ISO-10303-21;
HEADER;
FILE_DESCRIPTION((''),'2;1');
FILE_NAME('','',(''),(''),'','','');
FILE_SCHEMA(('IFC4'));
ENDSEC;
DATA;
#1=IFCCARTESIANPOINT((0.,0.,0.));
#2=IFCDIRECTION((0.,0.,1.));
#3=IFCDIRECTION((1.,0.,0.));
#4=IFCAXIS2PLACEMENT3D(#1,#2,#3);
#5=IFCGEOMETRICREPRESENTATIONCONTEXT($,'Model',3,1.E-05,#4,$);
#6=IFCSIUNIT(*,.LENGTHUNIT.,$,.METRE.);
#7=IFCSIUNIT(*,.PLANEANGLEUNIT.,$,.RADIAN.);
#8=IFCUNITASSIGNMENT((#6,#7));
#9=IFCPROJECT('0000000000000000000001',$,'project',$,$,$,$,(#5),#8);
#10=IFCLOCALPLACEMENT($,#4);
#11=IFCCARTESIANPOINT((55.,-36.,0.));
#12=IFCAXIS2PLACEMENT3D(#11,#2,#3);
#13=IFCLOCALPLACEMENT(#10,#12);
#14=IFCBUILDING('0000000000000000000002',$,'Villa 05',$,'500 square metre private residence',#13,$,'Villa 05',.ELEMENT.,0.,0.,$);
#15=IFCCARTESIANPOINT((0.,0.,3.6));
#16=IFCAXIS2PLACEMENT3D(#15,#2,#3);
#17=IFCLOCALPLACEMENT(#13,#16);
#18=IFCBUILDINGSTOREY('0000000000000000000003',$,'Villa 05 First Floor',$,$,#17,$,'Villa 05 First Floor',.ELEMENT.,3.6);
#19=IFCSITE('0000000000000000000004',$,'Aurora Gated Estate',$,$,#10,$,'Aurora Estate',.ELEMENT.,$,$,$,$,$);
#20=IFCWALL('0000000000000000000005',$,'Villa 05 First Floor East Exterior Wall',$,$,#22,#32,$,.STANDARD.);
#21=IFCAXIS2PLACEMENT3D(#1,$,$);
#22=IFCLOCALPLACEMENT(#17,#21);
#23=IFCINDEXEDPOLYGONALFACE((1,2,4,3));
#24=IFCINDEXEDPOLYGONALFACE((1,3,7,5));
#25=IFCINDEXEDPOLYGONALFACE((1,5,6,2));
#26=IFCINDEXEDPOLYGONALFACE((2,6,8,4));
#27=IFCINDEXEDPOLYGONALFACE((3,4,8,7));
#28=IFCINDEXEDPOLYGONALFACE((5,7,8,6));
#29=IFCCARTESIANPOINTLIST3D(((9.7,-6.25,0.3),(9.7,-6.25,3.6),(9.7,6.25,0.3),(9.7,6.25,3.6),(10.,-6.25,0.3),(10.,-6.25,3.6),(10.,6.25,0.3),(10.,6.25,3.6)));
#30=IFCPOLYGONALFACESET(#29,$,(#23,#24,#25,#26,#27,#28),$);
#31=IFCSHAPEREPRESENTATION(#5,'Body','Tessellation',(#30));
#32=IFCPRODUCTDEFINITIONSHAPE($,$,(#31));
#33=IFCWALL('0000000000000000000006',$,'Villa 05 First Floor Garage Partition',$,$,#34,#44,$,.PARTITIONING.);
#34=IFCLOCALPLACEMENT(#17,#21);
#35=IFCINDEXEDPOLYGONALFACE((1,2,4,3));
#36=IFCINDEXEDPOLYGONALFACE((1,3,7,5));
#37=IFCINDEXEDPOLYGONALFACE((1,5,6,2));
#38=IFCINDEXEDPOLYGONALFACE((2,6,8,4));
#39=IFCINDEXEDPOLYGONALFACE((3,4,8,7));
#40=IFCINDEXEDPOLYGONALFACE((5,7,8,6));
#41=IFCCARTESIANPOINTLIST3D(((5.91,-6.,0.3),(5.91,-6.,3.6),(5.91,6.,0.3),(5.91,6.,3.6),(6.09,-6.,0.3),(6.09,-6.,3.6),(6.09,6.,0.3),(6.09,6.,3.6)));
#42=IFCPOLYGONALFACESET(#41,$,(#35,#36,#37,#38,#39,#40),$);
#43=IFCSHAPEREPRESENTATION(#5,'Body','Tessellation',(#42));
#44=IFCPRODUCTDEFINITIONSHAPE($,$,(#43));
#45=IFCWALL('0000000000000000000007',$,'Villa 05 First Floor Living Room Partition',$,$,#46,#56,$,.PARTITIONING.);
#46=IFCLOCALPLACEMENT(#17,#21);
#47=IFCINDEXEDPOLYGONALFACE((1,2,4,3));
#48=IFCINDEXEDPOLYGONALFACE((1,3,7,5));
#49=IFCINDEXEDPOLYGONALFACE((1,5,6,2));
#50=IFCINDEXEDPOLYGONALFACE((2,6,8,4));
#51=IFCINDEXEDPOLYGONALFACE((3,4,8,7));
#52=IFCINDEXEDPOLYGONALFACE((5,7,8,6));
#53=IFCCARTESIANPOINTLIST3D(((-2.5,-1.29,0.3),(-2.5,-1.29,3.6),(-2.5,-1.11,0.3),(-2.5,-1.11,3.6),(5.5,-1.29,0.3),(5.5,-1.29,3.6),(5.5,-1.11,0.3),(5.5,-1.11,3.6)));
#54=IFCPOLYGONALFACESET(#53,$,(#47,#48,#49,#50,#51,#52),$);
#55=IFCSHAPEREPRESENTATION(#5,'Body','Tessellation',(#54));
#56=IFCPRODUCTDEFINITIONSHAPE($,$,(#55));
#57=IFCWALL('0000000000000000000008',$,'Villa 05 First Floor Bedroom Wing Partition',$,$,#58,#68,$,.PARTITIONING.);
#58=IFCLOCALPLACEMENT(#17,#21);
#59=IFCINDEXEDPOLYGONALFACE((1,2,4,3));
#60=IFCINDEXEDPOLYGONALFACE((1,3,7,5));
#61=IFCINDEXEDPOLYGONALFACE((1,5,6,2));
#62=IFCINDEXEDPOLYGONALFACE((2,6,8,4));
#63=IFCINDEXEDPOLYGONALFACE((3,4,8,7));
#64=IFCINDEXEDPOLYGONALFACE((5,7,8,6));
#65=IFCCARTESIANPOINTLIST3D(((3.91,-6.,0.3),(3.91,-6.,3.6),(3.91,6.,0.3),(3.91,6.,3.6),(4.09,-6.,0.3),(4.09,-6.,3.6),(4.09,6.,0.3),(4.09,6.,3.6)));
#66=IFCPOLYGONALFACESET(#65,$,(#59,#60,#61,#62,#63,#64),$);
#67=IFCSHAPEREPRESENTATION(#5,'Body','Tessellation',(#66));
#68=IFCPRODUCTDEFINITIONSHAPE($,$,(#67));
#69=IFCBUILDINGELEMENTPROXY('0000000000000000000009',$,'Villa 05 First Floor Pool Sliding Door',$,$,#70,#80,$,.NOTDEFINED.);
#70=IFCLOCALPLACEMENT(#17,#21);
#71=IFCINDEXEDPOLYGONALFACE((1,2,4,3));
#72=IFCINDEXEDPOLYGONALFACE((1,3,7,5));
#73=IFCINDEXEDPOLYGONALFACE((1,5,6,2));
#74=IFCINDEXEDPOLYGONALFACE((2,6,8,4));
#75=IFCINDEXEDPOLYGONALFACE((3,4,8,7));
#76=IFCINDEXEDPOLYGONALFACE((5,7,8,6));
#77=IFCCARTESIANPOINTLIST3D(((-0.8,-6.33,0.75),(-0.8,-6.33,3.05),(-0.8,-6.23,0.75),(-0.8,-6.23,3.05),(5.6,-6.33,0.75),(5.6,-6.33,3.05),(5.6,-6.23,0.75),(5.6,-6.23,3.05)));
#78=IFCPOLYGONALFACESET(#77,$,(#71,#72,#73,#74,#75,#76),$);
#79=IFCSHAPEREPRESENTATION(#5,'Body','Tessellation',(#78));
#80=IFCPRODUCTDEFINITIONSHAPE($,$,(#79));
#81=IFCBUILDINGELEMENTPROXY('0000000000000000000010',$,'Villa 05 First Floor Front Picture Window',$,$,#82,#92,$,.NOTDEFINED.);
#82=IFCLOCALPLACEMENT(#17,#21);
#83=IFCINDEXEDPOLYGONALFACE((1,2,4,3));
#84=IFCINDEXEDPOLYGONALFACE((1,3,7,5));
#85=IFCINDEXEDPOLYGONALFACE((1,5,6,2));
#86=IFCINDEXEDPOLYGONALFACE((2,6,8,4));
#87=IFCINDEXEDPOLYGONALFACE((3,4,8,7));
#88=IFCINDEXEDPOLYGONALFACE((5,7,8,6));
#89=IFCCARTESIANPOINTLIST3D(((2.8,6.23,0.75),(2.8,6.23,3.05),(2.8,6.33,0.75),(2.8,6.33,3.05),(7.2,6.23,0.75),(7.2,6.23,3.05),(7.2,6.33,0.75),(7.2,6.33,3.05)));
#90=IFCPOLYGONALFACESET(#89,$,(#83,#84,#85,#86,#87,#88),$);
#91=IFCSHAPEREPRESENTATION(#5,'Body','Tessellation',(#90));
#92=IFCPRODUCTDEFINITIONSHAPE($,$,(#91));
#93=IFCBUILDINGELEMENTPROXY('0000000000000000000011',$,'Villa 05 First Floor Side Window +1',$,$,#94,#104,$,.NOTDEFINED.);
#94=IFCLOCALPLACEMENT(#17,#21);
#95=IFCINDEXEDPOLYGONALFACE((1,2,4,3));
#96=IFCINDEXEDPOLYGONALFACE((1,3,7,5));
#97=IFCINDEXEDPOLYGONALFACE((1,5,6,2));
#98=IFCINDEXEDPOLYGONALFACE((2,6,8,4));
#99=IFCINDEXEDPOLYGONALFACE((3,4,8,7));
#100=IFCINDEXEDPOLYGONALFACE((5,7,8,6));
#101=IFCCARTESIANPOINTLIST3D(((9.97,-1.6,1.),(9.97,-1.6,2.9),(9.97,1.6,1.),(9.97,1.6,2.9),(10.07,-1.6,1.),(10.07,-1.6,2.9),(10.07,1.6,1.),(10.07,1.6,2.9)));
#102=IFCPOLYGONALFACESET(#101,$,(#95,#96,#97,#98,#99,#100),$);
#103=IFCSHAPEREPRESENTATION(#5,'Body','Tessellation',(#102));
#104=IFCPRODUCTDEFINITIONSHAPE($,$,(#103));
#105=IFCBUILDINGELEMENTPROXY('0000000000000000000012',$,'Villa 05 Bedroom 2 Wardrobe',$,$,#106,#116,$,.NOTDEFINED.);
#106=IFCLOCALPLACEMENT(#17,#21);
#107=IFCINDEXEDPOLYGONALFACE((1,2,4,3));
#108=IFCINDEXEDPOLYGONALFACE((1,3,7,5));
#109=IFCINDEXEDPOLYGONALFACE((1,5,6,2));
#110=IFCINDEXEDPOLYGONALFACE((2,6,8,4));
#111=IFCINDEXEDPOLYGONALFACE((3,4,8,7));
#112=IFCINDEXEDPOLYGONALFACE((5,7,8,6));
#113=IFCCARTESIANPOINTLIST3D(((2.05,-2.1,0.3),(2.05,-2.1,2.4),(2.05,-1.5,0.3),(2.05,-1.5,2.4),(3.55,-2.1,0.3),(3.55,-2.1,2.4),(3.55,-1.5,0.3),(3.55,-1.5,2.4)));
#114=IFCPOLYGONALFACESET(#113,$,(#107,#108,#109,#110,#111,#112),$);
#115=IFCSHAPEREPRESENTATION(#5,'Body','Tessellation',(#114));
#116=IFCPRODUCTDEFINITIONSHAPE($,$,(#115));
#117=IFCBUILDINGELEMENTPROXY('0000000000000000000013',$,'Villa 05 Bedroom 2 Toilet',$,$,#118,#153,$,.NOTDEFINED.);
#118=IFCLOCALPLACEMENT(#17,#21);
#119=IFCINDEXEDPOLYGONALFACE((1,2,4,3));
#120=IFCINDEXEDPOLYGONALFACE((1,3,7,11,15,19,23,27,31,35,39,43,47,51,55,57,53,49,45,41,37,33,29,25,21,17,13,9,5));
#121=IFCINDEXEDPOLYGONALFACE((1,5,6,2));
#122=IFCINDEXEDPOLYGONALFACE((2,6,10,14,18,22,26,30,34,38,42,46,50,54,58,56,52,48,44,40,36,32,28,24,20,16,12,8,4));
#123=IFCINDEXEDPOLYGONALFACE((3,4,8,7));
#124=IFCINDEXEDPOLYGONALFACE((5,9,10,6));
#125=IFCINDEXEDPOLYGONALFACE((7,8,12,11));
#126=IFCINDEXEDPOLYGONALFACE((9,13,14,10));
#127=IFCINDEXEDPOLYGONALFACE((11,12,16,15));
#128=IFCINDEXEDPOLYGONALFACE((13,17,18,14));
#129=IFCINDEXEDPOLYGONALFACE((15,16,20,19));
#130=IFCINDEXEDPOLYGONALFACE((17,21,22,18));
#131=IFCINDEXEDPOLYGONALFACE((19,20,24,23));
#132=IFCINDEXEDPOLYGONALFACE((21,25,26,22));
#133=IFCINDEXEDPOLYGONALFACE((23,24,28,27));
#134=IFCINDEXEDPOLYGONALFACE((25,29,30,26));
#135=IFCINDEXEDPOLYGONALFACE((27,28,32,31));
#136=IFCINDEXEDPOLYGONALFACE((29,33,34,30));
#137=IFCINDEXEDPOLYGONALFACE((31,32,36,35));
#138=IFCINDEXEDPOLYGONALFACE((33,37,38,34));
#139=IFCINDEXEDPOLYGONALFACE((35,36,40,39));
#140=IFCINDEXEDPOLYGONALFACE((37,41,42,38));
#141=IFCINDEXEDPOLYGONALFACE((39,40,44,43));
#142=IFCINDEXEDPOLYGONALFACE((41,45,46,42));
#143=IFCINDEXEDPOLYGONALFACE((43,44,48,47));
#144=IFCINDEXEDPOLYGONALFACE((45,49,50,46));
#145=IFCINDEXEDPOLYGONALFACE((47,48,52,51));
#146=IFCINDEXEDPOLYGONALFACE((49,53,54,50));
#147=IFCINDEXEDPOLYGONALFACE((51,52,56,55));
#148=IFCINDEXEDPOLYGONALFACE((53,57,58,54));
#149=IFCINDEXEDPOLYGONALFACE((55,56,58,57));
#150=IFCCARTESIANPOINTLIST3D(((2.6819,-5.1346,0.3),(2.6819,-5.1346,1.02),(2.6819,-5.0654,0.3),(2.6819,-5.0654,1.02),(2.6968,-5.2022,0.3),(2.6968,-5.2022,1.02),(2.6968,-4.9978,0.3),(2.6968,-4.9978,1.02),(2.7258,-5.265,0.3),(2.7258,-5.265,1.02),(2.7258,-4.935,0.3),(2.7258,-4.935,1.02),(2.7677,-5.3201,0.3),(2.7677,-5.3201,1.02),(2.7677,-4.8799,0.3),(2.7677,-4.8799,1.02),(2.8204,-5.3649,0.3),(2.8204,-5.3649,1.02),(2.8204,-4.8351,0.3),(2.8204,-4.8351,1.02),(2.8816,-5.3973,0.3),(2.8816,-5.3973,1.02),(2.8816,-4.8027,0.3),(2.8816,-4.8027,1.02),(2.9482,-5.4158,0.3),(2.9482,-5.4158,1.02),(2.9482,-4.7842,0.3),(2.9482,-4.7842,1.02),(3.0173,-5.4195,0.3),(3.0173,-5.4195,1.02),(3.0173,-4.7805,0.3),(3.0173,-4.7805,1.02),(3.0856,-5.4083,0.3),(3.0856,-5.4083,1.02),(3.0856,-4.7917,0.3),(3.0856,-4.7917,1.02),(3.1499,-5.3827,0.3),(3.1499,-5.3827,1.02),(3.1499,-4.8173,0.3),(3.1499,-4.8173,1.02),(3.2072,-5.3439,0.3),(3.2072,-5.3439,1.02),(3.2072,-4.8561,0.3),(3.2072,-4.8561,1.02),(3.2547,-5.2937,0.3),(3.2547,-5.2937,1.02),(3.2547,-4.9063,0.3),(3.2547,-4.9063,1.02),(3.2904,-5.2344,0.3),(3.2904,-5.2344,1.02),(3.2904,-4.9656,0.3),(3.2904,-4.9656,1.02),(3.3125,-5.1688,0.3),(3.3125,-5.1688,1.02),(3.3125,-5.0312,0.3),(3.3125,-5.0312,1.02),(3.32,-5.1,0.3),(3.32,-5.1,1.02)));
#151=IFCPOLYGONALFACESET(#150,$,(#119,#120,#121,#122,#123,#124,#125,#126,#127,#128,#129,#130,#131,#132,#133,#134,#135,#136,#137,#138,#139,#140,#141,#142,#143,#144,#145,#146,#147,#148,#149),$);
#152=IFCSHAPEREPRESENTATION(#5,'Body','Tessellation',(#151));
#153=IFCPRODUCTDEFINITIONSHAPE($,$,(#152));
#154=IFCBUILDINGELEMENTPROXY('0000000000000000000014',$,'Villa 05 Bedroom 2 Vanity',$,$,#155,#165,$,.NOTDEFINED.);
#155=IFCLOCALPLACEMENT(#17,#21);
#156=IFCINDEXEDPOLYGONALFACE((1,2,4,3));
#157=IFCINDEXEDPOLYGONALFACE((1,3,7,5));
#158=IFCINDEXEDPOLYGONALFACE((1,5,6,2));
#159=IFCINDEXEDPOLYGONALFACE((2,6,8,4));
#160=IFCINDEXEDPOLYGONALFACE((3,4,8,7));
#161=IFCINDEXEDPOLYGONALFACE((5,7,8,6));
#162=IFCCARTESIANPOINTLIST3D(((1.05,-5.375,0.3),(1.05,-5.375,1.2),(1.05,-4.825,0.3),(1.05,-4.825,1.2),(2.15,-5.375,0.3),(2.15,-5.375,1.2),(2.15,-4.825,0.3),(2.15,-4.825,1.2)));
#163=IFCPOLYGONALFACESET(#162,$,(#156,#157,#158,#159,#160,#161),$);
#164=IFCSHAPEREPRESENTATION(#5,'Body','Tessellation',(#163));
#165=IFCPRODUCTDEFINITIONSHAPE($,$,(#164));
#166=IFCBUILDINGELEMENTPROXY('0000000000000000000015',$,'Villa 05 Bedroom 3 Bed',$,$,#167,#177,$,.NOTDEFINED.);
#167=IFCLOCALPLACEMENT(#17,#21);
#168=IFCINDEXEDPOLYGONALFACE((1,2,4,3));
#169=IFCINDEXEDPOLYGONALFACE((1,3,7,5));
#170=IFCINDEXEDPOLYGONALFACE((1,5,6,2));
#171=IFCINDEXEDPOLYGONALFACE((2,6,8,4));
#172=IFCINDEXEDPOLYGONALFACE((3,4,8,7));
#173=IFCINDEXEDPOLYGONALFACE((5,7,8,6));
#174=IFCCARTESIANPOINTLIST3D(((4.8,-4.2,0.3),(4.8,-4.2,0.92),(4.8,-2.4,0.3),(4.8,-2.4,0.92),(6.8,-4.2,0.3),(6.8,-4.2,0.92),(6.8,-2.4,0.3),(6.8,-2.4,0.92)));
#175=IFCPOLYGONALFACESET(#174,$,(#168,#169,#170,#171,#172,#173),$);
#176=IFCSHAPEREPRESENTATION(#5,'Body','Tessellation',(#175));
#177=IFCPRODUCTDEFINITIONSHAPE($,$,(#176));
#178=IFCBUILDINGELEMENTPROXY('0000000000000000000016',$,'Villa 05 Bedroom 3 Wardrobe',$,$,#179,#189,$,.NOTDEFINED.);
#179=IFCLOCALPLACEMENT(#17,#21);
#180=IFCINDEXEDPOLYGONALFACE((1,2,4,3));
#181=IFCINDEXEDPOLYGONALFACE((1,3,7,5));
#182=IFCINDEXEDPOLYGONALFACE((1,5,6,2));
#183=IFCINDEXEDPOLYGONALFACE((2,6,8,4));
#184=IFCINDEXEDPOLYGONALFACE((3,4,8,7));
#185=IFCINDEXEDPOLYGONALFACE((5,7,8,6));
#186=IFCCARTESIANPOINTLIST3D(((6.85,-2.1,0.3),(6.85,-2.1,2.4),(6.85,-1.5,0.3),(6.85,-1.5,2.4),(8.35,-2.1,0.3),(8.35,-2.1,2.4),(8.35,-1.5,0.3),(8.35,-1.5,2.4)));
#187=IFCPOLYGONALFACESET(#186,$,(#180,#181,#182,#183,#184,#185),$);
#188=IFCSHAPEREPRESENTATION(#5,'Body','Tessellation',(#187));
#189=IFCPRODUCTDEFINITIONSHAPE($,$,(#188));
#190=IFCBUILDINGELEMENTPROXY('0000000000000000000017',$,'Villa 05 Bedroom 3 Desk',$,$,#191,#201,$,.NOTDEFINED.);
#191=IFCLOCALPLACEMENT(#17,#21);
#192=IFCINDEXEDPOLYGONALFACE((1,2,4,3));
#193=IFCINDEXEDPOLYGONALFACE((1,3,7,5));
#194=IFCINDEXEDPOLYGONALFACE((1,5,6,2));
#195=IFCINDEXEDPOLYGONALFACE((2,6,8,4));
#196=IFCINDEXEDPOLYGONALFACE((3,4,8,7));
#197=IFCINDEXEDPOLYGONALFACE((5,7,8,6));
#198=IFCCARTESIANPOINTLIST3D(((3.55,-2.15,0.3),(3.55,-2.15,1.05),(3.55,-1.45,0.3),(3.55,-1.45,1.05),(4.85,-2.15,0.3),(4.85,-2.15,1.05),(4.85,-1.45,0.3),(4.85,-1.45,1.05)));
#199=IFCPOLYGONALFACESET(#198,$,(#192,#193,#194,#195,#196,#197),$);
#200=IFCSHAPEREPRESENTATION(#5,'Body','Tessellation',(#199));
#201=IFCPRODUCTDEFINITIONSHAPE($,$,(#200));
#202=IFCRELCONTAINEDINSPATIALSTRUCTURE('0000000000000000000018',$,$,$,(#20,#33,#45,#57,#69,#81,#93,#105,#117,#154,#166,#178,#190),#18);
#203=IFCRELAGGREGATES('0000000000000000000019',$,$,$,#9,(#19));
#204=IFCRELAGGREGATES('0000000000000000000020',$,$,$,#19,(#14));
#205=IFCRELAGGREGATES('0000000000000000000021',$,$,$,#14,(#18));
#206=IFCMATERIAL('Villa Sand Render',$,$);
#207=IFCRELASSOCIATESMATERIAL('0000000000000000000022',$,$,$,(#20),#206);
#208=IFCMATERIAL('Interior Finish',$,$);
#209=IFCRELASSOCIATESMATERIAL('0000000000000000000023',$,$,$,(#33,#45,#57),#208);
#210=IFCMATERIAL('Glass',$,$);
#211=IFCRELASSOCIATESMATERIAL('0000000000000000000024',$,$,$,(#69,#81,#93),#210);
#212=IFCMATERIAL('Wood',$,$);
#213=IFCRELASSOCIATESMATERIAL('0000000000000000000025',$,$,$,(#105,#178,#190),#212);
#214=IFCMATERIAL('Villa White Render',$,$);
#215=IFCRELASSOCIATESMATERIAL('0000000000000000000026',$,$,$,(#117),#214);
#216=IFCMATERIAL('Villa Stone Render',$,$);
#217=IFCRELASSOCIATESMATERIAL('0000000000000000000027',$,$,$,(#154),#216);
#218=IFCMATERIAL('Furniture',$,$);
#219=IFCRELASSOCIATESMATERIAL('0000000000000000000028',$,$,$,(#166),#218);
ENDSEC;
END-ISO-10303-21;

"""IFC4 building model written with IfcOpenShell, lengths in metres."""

from ifc_helpers import new_model, si_unit, frame, origin_with_axes, origin_2d_with_axis, place, context, project, spatial, rectangle, circle, extrude, material, element, save


model = new_model("IFC4")

# Units and contexts
model_context = context("Model", 3, precision=1e-05, world=origin_with_axes())
ifc_project = project(units=[si_unit("LENGTHUNIT", "METRE"), si_unit("PLANEANGLEUNIT", "RADIAN")], contexts=[model_context])

# Site, building, storey
site_placement = place(None, origin_with_axes())
site = spatial("IfcSite", under=ifc_project, at=site_placement, Name="Aurora Gated Estate", LongName="Aurora Estate", CompositionType="ELEMENT")
building_placement = place(site_placement, frame((55.0, -36.0, 0.0), z_axis=(0.0, 0.0, 1.0), x_axis=(1.0, 0.0, 0.0)))
building = spatial("IfcBuilding", under=site, at=building_placement, Name="Villa 05", ObjectType="500 square metre private residence", LongName="Villa 05", CompositionType="ELEMENT", ElevationOfRefHeight=0.0, ElevationOfTerrain=0.0)
storey_placement = place(building_placement, frame((0.0, 0.0, 3.6), z_axis=(0.0, 0.0, 1.0), x_axis=(1.0, 0.0, 0.0)))
storey = spatial("IfcBuildingStorey", under=building, at=storey_placement, Name="Villa 05 First Floor", LongName="Villa 05 First Floor", CompositionType="ELEMENT", Elevation=3.6)

# Walls
ifc_material_1 = material(Name="Villa Sand Render")
wall_1_placement = place(storey_placement, frame((9.85, 0.0, 0.3), z_axis=(0.0, 0.0, 1.0), x_axis=(1.0, 0.0, 0.0)))
element("IfcWall", 1, at=wall_1_placement, inside=storey, material=ifc_material_1, Name="Villa 05 First Floor East Exterior Wall", PredefinedType="STANDARD", context=model_context, shape_type="SweptSolid", body=[
    extrude(rectangle(XDim=0.3, YDim=12.5, at=origin_2d_with_axis()), origin_with_axes(), (0.0, 0.0, 1.0), 3.3),
])
ifc_material_2 = material(Name="Interior Finish")
wall_2_placement = place(storey_placement, frame((6.0, 0.0, 0.3), z_axis=(0.0, 0.0, 1.0), x_axis=(1.0, 0.0, 0.0)))
element("IfcWall", 2, at=wall_2_placement, inside=storey, material=ifc_material_2, Name="Villa 05 First Floor Garage Partition", PredefinedType="PARTITIONING", context=model_context, shape_type="SweptSolid", body=[
    extrude(rectangle(XDim=0.18, YDim=12.0, at=origin_2d_with_axis()), origin_with_axes(), (0.0, 0.0, 1.0), 3.3),
])
wall_3_placement = place(storey_placement, frame((1.5, -1.2, 0.3), z_axis=(0.0, 0.0, 1.0), x_axis=(1.0, 0.0, 0.0)))
element("IfcWall", 3, at=wall_3_placement, inside=storey, material=ifc_material_2, Name="Villa 05 First Floor Living Room Partition", PredefinedType="PARTITIONING", context=model_context, shape_type="SweptSolid", body=[
    extrude(rectangle(XDim=8.0, YDim=0.18, at=origin_2d_with_axis()), origin_with_axes(), (0.0, 0.0, 1.0), 3.3),
])
wall_4_placement = place(storey_placement, frame((4.0, 0.0, 0.3), z_axis=(0.0, 0.0, 1.0), x_axis=(1.0, 0.0, 0.0)))
element("IfcWall", 4, at=wall_4_placement, inside=storey, material=ifc_material_2, Name="Villa 05 First Floor Bedroom Wing Partition", PredefinedType="PARTITIONING", context=model_context, shape_type="SweptSolid", body=[
    extrude(rectangle(XDim=0.18, YDim=12.0, at=origin_2d_with_axis()), origin_with_axes(), (0.0, 0.0, 1.0), 3.3),
])

# Building element proxies
ifc_material_3 = material(Name="Glass")
proxy_1_placement = place(storey_placement, frame((2.4, -6.28, 0.75), z_axis=(0.0, 0.0, 1.0), x_axis=(1.0, 0.0, 0.0)))
element("IfcBuildingElementProxy", 5, at=proxy_1_placement, inside=storey, material=ifc_material_3, Name="Villa 05 First Floor Pool Sliding Door", PredefinedType="NOTDEFINED", context=model_context, shape_type="SweptSolid", body=[
    extrude(rectangle(XDim=6.4, YDim=0.1, at=origin_2d_with_axis()), origin_with_axes(), (0.0, 0.0, 1.0), 2.3),
])
proxy_2_placement = place(storey_placement, frame((5.0, 6.28, 0.75), z_axis=(0.0, 0.0, 1.0), x_axis=(1.0, 0.0, 0.0)))
element("IfcBuildingElementProxy", 6, at=proxy_2_placement, inside=storey, material=ifc_material_3, Name="Villa 05 First Floor Front Picture Window", PredefinedType="NOTDEFINED", context=model_context, shape_type="SweptSolid", body=[
    extrude(rectangle(XDim=4.4, YDim=0.1, at=origin_2d_with_axis()), origin_with_axes(), (0.0, 0.0, 1.0), 2.3),
])
proxy_3_placement = place(storey_placement, frame((10.02, 0.0, 1.0), z_axis=(0.0, 0.0, 1.0), x_axis=(0.0, 1.0, 0.0)))
element("IfcBuildingElementProxy", 7, at=proxy_3_placement, inside=storey, material=ifc_material_3, Name="Villa 05 First Floor Side Window +1", PredefinedType="NOTDEFINED", context=model_context, shape_type="SweptSolid", body=[
    extrude(rectangle(XDim=3.2, YDim=0.1, at=origin_2d_with_axis()), origin_with_axes(), (0.0, 0.0, 1.0), 1.9),
])
ifc_material_4 = material(Name="Wood")
proxy_4_placement = place(storey_placement, frame((2.8, -1.8, 0.3), z_axis=(0.0, 0.0, 1.0), x_axis=(1.0, 0.0, 0.0)))
element("IfcBuildingElementProxy", 8, at=proxy_4_placement, inside=storey, material=ifc_material_4, Name="Villa 05 Bedroom 2 Wardrobe", PredefinedType="NOTDEFINED", context=model_context, shape_type="SweptSolid", body=[
    extrude(rectangle(XDim=1.5, YDim=0.6, at=origin_2d_with_axis()), origin_with_axes(), (0.0, 0.0, 1.0), 2.1),
])
ifc_material_5 = material(Name="Villa White Render")
proxy_5_placement = place(storey_placement, frame((3.0, -5.1, 0.3), z_axis=(0.0, 0.0, 1.0), x_axis=(1.0, 0.0, 0.0)))
element("IfcBuildingElementProxy", 9, at=proxy_5_placement, inside=storey, material=ifc_material_5, Name="Villa 05 Bedroom 2 Toilet", PredefinedType="NOTDEFINED", context=model_context, shape_type="SweptSolid", body=[
    extrude(circle(Radius=0.32, at=origin_2d_with_axis()), origin_with_axes(), (0.0, 0.0, 1.0), 0.72),
])
ifc_material_6 = material(Name="Villa Stone Render")
proxy_6_placement = place(storey_placement, frame((1.6, -5.1, 0.3), z_axis=(0.0, 0.0, 1.0), x_axis=(1.0, 0.0, 0.0)))
element("IfcBuildingElementProxy", 10, at=proxy_6_placement, inside=storey, material=ifc_material_6, Name="Villa 05 Bedroom 2 Vanity", PredefinedType="NOTDEFINED", context=model_context, shape_type="SweptSolid", body=[
    extrude(rectangle(XDim=1.1, YDim=0.55, at=origin_2d_with_axis()), origin_with_axes(), (0.0, 0.0, 1.0), 0.9),
])
ifc_material_7 = material(Name="Furniture")
proxy_7_placement = place(storey_placement, frame((5.8, -3.3, 0.3), z_axis=(0.0, 0.0, 1.0), x_axis=(1.0, 0.0, 0.0)))
element("IfcBuildingElementProxy", 11, at=proxy_7_placement, inside=storey, material=ifc_material_7, Name="Villa 05 Bedroom 3 Bed", PredefinedType="NOTDEFINED", context=model_context, shape_type="SweptSolid", body=[
    extrude(rectangle(XDim=2.0, YDim=1.8, at=origin_2d_with_axis()), origin_with_axes(), (0.0, 0.0, 1.0), 0.62),
])
proxy_8_placement = place(storey_placement, frame((7.6, -1.8, 0.3), z_axis=(0.0, 0.0, 1.0), x_axis=(1.0, 0.0, 0.0)))
element("IfcBuildingElementProxy", 12, at=proxy_8_placement, inside=storey, material=ifc_material_4, Name="Villa 05 Bedroom 3 Wardrobe", PredefinedType="NOTDEFINED", context=model_context, shape_type="SweptSolid", body=[
    extrude(rectangle(XDim=1.5, YDim=0.6, at=origin_2d_with_axis()), origin_with_axes(), (0.0, 0.0, 1.0), 2.1),
])
proxy_9_placement = place(storey_placement, frame((4.2, -1.8, 0.3), z_axis=(0.0, 0.0, 1.0), x_axis=(1.0, 0.0, 0.0)))
element("IfcBuildingElementProxy", 13, at=proxy_9_placement, inside=storey, material=ifc_material_4, Name="Villa 05 Bedroom 3 Desk", PredefinedType="NOTDEFINED", context=model_context, shape_type="SweptSolid", body=[
    extrude(rectangle(XDim=1.3, YDim=0.7, at=origin_2d_with_axis()), origin_with_axes(), (0.0, 0.0, 1.0), 0.75),
])

save(model, "model.ifc")
